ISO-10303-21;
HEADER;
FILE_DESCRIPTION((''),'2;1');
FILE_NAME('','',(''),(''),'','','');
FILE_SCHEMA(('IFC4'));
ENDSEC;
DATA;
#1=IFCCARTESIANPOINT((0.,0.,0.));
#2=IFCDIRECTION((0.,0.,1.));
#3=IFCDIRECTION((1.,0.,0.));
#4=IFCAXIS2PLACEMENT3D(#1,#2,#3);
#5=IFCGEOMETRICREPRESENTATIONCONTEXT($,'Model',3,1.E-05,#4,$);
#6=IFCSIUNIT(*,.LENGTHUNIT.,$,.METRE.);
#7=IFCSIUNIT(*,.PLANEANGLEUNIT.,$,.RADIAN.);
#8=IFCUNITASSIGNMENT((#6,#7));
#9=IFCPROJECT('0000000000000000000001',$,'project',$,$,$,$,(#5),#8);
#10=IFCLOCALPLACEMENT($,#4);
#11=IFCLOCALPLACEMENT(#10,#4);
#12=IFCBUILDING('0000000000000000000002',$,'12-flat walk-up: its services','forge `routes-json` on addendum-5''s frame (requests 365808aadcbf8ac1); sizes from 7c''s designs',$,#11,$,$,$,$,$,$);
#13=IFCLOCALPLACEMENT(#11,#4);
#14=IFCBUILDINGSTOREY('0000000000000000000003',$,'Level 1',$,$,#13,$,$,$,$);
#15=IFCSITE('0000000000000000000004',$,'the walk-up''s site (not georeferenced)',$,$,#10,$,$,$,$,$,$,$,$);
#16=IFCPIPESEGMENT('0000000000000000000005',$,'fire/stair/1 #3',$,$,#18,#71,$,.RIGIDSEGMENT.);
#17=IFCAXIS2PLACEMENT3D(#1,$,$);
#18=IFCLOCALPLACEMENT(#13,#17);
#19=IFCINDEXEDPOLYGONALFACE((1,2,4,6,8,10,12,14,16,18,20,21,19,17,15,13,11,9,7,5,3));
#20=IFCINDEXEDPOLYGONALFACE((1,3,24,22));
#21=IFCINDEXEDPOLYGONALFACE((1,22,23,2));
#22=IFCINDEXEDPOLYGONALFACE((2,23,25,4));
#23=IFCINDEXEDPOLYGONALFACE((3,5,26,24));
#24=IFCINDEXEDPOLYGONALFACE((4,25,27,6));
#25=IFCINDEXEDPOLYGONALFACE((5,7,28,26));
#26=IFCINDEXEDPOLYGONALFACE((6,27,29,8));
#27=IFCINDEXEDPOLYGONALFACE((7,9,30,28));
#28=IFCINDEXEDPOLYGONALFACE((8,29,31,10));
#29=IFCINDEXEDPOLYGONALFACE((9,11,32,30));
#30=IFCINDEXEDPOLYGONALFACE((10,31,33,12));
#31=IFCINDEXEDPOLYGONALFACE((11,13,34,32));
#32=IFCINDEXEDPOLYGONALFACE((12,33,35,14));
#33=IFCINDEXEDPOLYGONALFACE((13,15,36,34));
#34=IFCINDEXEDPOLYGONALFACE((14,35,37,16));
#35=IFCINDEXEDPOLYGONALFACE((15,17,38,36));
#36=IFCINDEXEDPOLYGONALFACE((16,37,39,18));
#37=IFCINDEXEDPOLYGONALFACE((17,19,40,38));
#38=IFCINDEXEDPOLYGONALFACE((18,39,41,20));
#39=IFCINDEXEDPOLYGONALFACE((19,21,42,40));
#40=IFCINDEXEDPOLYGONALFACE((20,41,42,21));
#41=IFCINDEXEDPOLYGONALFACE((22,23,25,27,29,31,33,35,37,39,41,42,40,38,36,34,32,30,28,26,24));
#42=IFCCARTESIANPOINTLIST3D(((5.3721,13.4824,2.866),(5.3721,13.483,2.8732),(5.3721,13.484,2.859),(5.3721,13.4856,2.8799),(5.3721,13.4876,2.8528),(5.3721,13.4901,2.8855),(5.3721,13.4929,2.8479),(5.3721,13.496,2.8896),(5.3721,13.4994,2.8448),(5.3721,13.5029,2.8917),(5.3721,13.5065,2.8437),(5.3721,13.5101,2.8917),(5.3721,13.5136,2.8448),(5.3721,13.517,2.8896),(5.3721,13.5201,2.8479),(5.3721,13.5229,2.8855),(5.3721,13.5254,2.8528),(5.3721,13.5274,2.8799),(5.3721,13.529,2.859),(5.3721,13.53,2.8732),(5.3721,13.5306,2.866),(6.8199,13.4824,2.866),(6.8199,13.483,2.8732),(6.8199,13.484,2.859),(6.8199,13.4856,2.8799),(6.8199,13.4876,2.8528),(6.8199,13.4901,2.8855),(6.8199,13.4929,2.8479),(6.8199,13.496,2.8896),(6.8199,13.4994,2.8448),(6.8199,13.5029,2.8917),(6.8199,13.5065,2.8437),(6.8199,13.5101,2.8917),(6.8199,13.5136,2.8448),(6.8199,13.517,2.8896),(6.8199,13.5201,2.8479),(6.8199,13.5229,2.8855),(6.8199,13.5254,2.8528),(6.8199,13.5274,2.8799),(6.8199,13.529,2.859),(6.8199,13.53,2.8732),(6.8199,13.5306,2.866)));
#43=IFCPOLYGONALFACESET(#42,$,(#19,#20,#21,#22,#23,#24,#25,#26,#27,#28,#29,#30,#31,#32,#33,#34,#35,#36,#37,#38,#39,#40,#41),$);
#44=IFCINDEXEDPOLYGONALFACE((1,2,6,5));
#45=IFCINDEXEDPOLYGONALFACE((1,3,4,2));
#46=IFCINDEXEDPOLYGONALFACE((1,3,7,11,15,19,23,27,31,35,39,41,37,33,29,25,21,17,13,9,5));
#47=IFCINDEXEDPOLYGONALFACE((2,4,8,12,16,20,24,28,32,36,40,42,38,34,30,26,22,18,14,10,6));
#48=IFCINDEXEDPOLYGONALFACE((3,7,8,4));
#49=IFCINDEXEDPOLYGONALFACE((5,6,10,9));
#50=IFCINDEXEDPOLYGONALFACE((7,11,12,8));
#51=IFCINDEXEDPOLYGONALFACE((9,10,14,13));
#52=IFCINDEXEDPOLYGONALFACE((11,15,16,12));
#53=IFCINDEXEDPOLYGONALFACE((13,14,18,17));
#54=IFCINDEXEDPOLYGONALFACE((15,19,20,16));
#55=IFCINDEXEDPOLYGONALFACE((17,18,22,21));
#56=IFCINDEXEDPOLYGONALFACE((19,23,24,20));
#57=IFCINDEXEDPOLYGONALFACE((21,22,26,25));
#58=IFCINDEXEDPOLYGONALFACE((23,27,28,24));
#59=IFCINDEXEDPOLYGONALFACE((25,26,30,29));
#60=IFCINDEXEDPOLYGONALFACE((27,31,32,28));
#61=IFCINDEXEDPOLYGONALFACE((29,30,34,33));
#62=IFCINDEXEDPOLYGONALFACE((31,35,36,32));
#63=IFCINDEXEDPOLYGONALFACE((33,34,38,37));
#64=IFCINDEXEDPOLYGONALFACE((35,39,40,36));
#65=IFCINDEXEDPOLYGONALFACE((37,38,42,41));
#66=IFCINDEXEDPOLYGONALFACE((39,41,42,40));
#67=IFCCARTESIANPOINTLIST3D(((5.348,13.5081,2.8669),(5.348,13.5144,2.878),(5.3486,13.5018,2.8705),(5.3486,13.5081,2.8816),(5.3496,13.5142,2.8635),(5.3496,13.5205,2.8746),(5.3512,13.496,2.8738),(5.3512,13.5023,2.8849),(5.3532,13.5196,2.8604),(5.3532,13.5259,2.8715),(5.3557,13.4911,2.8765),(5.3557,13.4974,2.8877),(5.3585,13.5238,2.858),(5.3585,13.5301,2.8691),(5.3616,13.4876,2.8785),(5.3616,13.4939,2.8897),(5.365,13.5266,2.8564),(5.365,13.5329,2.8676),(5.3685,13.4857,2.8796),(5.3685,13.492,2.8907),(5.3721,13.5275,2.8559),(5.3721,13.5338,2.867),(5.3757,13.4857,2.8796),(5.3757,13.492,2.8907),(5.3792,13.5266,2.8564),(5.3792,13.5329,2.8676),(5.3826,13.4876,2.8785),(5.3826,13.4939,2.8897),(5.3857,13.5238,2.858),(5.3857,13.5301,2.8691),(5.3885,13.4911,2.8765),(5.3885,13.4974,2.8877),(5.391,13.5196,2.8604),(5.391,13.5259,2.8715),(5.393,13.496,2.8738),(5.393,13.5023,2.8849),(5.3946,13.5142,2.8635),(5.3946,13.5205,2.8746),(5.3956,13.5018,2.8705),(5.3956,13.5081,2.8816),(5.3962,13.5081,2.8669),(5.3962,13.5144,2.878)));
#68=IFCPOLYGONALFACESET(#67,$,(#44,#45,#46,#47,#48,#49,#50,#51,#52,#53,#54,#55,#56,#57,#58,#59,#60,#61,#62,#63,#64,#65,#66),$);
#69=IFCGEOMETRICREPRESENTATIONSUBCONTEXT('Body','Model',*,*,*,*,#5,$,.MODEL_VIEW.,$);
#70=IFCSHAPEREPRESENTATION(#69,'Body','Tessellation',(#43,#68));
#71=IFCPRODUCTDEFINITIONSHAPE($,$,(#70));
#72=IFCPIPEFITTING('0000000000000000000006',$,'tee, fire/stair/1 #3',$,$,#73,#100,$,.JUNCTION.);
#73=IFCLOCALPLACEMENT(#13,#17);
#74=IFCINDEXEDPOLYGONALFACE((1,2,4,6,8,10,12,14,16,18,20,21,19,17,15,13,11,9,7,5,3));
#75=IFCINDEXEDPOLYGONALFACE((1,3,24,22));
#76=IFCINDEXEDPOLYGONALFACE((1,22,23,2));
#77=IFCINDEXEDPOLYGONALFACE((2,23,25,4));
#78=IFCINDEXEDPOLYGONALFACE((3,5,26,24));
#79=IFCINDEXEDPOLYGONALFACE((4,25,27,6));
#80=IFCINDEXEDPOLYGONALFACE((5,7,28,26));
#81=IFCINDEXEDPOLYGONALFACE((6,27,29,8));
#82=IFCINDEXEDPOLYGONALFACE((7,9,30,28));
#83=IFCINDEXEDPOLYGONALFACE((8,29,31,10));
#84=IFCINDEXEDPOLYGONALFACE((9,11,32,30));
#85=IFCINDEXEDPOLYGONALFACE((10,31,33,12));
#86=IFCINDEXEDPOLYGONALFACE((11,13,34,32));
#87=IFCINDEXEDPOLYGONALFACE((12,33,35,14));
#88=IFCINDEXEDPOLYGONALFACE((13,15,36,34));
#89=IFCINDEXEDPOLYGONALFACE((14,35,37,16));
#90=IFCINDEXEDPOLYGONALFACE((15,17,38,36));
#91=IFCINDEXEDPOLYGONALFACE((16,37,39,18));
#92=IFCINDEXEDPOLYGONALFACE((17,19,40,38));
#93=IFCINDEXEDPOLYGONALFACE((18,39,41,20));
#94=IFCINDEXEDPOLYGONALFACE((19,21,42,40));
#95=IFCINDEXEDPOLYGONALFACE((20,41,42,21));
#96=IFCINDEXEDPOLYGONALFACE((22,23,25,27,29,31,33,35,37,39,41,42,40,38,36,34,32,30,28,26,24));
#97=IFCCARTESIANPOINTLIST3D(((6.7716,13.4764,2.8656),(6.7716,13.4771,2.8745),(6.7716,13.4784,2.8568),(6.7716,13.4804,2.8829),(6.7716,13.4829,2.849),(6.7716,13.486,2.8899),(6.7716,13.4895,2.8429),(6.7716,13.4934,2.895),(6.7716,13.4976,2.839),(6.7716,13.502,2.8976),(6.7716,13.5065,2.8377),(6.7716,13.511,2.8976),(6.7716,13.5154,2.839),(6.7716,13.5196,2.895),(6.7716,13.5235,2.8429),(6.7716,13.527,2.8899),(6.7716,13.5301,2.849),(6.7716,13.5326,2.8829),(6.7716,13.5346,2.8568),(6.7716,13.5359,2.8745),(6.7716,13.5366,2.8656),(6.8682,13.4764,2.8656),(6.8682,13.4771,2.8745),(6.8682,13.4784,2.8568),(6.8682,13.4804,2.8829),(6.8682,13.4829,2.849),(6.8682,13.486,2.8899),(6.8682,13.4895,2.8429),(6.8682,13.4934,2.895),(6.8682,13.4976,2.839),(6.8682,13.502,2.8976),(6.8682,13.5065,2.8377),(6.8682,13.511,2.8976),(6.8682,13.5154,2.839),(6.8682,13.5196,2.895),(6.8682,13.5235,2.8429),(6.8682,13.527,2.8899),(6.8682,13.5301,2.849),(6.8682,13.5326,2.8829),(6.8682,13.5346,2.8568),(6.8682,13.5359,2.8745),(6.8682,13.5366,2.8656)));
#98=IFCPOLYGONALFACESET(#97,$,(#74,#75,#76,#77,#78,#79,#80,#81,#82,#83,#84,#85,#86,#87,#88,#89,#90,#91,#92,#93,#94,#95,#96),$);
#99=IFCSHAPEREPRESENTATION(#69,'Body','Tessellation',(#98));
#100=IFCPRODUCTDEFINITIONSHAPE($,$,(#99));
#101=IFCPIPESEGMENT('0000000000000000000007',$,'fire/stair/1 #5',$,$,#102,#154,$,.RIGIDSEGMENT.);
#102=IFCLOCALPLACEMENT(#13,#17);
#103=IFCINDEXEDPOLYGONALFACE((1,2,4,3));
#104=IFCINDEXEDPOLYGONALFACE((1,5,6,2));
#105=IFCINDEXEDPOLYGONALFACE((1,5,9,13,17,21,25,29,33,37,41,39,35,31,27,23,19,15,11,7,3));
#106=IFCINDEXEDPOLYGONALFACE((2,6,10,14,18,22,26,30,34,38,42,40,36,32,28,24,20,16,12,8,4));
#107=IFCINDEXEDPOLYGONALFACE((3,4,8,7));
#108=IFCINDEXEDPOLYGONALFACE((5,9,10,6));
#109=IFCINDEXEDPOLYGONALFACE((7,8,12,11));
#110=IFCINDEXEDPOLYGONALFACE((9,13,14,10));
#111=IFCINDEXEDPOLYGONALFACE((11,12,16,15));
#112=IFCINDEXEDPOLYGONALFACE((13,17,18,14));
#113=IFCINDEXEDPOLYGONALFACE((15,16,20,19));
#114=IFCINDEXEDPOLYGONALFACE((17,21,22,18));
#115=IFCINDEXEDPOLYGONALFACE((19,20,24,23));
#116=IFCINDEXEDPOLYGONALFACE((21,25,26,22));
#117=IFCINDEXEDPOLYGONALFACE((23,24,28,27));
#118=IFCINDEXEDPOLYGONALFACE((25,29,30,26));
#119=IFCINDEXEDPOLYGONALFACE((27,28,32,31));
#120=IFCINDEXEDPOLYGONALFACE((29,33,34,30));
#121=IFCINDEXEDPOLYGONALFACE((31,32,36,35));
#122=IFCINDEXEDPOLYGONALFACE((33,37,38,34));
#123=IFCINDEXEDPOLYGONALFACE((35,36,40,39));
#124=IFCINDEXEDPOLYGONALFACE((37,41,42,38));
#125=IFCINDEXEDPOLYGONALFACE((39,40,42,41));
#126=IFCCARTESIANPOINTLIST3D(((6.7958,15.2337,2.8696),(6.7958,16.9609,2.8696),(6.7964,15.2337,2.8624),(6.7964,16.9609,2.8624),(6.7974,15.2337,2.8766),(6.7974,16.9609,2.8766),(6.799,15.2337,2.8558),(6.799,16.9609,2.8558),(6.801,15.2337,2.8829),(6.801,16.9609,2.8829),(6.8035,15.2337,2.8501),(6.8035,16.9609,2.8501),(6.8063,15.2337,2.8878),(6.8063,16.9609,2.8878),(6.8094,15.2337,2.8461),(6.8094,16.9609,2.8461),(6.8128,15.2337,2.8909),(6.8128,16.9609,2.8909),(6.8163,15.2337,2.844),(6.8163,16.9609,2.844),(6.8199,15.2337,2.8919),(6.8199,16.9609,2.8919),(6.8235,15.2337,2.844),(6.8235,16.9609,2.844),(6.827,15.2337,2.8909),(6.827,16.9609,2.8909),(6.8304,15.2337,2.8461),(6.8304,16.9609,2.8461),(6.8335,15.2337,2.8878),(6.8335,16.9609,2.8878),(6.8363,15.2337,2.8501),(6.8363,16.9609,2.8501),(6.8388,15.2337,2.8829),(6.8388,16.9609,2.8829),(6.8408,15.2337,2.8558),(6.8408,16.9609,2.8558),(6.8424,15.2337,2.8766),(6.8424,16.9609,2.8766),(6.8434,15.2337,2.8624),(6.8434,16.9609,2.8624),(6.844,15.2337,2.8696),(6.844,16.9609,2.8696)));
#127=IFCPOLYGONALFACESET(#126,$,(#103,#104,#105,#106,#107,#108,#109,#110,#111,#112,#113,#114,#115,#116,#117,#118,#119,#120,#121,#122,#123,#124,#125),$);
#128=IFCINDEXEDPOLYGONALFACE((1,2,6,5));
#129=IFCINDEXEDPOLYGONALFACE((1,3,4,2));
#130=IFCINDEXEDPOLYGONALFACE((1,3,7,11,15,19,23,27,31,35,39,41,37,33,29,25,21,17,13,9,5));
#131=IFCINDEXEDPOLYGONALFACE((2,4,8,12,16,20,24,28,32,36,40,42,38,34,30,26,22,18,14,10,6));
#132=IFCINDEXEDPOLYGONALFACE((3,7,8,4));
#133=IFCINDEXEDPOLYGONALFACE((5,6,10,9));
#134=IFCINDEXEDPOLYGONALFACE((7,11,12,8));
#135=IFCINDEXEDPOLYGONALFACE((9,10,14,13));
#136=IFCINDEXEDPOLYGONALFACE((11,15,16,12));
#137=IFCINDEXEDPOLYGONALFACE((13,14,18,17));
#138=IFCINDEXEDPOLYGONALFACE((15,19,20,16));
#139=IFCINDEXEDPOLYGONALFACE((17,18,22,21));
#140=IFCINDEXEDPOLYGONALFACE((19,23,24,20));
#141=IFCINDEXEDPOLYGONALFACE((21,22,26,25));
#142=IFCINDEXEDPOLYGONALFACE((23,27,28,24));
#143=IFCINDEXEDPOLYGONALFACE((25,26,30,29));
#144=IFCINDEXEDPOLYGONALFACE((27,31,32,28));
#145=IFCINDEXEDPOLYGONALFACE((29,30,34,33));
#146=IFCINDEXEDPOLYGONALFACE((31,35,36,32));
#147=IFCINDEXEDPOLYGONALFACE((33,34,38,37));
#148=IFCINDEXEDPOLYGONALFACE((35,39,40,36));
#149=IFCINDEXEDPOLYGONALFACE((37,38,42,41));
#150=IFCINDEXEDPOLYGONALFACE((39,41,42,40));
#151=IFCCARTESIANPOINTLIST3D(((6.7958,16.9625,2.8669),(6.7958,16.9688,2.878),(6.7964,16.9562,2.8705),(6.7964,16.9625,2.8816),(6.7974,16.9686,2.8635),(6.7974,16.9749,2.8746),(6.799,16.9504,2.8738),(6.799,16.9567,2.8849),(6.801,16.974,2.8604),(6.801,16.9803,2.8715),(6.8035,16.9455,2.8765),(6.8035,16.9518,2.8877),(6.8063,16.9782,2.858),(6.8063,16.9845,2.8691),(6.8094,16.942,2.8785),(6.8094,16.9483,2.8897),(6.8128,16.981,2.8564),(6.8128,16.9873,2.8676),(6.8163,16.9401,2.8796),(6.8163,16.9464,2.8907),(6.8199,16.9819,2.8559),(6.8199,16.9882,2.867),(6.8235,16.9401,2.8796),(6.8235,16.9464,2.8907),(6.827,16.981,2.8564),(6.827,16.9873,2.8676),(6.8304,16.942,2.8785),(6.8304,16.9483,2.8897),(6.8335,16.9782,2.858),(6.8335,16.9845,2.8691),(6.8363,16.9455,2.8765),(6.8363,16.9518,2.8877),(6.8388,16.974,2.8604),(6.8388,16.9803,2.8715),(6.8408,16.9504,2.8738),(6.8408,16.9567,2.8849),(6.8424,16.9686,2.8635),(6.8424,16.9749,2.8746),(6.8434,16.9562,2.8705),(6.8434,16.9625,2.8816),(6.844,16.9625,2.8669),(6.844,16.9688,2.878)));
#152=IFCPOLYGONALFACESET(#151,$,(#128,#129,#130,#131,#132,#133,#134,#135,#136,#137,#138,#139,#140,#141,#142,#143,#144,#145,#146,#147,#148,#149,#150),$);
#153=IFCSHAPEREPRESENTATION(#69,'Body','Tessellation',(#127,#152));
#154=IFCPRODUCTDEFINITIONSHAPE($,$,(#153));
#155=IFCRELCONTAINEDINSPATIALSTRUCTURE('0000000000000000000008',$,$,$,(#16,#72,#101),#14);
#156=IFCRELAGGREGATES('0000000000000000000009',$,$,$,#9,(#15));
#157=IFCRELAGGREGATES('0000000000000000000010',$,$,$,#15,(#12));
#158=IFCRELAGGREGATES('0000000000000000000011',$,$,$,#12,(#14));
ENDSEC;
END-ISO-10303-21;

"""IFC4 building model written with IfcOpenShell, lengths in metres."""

from ifc_helpers import new_model, entity, si_unit, frame, origin_with_axes, place, context, subcontext, project, spatial, element, save


model = new_model("IFC4")

# Units and contexts
model_context = context("Model", 3, precision=1e-05, world=origin_with_axes())
body_context = subcontext(model_context, "Body", "Model", "MODEL_VIEW")
ifc_project = project(units=[si_unit("LENGTHUNIT", "METRE"), si_unit("PLANEANGLEUNIT", "RADIAN")], contexts=[model_context])

# Site, building, storey
site_placement = place(None, origin_with_axes())
site = spatial("IfcSite", under=ifc_project, at=site_placement, Name="the walk-up's site (not georeferenced)")
building_placement = place(site_placement, origin_with_axes())
building = spatial("IfcBuilding", under=site, at=building_placement, Name="12-flat walk-up: its services", Description="forge `routes-json` on addendum-5's frame (requests 365808aadcbf8ac1); sizes from 7c's designs")
storey_placement = place(building_placement, origin_with_axes())
storey = spatial("IfcBuildingStorey", under=building, at=storey_placement, Name="Level 1")

# Pipe segment
pipe_segment_1_placement = place(storey_placement, frame((6.8199, 13.5065, 2.8678), z_axis=(0.0, 0.0, 1.0), x_axis=(1.0, 0.0, 0.0)))
element("IfcPipeSegment", 1, at=pipe_segment_1_placement, inside=storey, Name="fire/stair/1 #3", PredefinedType="RIGIDSEGMENT", context=body_context, shape_type="AdvancedSweptSolid", body=[
    entity("IfcSweptDiskSolid", entity("IfcPolyline", [entity("IfcCartesianPoint", [0.0, 0.0, 0.0]), entity("IfcCartesianPoint", [-1.4478, 0.0, 0.0])]), 0.0241),
    entity("IfcSweptDiskSolid", entity("IfcPolyline", [entity("IfcCartesianPoint", [-1.4478, 0.0, 0.0]), entity("IfcCartesianPoint", [-1.4478, 0.0063, 0.0111])]), 0.0241),
])

# Pipe fitting
pipe_fitting_1_placement = place(storey_placement, frame((6.8682, 13.5065, 2.8678), z_axis=(0.0, 0.0, 1.0), x_axis=(1.0, 0.0, 0.0)))
element("IfcPipeFitting", 2, at=pipe_fitting_1_placement, inside=storey, Name="tee, fire/stair/1 #3", PredefinedType="JUNCTION", context=body_context, shape_type="AdvancedSweptSolid", body=[
    entity("IfcSweptDiskSolid", entity("IfcPolyline", [entity("IfcCartesianPoint", [0.0, 0.0, 0.0]), entity("IfcCartesianPoint", [-0.0965, 0.0, 0.0])]), 0.0302),
])

# Pipe segment
pipe_segment_2_placement = place(storey_placement, frame((6.8199, 15.2337, 2.8678), z_axis=(0.0, 0.0, 1.0), x_axis=(1.0, 0.0, 0.0)))
element("IfcPipeSegment", 3, at=pipe_segment_2_placement, inside=storey, Name="fire/stair/1 #5", PredefinedType="RIGIDSEGMENT", context=body_context, shape_type="AdvancedSweptSolid", body=[
    entity("IfcSweptDiskSolid", entity("IfcPolyline", [entity("IfcCartesianPoint", [0.0, 0.0, 0.0]), entity("IfcCartesianPoint", [0.0, 1.7272, 0.0])]), 0.0241),
    entity("IfcSweptDiskSolid", entity("IfcPolyline", [entity("IfcCartesianPoint", [0.0, 1.7272, 0.0]), entity("IfcCartesianPoint", [0.0, 1.7335, 0.0111])]), 0.0241),
])

save(model, "model.ifc")
